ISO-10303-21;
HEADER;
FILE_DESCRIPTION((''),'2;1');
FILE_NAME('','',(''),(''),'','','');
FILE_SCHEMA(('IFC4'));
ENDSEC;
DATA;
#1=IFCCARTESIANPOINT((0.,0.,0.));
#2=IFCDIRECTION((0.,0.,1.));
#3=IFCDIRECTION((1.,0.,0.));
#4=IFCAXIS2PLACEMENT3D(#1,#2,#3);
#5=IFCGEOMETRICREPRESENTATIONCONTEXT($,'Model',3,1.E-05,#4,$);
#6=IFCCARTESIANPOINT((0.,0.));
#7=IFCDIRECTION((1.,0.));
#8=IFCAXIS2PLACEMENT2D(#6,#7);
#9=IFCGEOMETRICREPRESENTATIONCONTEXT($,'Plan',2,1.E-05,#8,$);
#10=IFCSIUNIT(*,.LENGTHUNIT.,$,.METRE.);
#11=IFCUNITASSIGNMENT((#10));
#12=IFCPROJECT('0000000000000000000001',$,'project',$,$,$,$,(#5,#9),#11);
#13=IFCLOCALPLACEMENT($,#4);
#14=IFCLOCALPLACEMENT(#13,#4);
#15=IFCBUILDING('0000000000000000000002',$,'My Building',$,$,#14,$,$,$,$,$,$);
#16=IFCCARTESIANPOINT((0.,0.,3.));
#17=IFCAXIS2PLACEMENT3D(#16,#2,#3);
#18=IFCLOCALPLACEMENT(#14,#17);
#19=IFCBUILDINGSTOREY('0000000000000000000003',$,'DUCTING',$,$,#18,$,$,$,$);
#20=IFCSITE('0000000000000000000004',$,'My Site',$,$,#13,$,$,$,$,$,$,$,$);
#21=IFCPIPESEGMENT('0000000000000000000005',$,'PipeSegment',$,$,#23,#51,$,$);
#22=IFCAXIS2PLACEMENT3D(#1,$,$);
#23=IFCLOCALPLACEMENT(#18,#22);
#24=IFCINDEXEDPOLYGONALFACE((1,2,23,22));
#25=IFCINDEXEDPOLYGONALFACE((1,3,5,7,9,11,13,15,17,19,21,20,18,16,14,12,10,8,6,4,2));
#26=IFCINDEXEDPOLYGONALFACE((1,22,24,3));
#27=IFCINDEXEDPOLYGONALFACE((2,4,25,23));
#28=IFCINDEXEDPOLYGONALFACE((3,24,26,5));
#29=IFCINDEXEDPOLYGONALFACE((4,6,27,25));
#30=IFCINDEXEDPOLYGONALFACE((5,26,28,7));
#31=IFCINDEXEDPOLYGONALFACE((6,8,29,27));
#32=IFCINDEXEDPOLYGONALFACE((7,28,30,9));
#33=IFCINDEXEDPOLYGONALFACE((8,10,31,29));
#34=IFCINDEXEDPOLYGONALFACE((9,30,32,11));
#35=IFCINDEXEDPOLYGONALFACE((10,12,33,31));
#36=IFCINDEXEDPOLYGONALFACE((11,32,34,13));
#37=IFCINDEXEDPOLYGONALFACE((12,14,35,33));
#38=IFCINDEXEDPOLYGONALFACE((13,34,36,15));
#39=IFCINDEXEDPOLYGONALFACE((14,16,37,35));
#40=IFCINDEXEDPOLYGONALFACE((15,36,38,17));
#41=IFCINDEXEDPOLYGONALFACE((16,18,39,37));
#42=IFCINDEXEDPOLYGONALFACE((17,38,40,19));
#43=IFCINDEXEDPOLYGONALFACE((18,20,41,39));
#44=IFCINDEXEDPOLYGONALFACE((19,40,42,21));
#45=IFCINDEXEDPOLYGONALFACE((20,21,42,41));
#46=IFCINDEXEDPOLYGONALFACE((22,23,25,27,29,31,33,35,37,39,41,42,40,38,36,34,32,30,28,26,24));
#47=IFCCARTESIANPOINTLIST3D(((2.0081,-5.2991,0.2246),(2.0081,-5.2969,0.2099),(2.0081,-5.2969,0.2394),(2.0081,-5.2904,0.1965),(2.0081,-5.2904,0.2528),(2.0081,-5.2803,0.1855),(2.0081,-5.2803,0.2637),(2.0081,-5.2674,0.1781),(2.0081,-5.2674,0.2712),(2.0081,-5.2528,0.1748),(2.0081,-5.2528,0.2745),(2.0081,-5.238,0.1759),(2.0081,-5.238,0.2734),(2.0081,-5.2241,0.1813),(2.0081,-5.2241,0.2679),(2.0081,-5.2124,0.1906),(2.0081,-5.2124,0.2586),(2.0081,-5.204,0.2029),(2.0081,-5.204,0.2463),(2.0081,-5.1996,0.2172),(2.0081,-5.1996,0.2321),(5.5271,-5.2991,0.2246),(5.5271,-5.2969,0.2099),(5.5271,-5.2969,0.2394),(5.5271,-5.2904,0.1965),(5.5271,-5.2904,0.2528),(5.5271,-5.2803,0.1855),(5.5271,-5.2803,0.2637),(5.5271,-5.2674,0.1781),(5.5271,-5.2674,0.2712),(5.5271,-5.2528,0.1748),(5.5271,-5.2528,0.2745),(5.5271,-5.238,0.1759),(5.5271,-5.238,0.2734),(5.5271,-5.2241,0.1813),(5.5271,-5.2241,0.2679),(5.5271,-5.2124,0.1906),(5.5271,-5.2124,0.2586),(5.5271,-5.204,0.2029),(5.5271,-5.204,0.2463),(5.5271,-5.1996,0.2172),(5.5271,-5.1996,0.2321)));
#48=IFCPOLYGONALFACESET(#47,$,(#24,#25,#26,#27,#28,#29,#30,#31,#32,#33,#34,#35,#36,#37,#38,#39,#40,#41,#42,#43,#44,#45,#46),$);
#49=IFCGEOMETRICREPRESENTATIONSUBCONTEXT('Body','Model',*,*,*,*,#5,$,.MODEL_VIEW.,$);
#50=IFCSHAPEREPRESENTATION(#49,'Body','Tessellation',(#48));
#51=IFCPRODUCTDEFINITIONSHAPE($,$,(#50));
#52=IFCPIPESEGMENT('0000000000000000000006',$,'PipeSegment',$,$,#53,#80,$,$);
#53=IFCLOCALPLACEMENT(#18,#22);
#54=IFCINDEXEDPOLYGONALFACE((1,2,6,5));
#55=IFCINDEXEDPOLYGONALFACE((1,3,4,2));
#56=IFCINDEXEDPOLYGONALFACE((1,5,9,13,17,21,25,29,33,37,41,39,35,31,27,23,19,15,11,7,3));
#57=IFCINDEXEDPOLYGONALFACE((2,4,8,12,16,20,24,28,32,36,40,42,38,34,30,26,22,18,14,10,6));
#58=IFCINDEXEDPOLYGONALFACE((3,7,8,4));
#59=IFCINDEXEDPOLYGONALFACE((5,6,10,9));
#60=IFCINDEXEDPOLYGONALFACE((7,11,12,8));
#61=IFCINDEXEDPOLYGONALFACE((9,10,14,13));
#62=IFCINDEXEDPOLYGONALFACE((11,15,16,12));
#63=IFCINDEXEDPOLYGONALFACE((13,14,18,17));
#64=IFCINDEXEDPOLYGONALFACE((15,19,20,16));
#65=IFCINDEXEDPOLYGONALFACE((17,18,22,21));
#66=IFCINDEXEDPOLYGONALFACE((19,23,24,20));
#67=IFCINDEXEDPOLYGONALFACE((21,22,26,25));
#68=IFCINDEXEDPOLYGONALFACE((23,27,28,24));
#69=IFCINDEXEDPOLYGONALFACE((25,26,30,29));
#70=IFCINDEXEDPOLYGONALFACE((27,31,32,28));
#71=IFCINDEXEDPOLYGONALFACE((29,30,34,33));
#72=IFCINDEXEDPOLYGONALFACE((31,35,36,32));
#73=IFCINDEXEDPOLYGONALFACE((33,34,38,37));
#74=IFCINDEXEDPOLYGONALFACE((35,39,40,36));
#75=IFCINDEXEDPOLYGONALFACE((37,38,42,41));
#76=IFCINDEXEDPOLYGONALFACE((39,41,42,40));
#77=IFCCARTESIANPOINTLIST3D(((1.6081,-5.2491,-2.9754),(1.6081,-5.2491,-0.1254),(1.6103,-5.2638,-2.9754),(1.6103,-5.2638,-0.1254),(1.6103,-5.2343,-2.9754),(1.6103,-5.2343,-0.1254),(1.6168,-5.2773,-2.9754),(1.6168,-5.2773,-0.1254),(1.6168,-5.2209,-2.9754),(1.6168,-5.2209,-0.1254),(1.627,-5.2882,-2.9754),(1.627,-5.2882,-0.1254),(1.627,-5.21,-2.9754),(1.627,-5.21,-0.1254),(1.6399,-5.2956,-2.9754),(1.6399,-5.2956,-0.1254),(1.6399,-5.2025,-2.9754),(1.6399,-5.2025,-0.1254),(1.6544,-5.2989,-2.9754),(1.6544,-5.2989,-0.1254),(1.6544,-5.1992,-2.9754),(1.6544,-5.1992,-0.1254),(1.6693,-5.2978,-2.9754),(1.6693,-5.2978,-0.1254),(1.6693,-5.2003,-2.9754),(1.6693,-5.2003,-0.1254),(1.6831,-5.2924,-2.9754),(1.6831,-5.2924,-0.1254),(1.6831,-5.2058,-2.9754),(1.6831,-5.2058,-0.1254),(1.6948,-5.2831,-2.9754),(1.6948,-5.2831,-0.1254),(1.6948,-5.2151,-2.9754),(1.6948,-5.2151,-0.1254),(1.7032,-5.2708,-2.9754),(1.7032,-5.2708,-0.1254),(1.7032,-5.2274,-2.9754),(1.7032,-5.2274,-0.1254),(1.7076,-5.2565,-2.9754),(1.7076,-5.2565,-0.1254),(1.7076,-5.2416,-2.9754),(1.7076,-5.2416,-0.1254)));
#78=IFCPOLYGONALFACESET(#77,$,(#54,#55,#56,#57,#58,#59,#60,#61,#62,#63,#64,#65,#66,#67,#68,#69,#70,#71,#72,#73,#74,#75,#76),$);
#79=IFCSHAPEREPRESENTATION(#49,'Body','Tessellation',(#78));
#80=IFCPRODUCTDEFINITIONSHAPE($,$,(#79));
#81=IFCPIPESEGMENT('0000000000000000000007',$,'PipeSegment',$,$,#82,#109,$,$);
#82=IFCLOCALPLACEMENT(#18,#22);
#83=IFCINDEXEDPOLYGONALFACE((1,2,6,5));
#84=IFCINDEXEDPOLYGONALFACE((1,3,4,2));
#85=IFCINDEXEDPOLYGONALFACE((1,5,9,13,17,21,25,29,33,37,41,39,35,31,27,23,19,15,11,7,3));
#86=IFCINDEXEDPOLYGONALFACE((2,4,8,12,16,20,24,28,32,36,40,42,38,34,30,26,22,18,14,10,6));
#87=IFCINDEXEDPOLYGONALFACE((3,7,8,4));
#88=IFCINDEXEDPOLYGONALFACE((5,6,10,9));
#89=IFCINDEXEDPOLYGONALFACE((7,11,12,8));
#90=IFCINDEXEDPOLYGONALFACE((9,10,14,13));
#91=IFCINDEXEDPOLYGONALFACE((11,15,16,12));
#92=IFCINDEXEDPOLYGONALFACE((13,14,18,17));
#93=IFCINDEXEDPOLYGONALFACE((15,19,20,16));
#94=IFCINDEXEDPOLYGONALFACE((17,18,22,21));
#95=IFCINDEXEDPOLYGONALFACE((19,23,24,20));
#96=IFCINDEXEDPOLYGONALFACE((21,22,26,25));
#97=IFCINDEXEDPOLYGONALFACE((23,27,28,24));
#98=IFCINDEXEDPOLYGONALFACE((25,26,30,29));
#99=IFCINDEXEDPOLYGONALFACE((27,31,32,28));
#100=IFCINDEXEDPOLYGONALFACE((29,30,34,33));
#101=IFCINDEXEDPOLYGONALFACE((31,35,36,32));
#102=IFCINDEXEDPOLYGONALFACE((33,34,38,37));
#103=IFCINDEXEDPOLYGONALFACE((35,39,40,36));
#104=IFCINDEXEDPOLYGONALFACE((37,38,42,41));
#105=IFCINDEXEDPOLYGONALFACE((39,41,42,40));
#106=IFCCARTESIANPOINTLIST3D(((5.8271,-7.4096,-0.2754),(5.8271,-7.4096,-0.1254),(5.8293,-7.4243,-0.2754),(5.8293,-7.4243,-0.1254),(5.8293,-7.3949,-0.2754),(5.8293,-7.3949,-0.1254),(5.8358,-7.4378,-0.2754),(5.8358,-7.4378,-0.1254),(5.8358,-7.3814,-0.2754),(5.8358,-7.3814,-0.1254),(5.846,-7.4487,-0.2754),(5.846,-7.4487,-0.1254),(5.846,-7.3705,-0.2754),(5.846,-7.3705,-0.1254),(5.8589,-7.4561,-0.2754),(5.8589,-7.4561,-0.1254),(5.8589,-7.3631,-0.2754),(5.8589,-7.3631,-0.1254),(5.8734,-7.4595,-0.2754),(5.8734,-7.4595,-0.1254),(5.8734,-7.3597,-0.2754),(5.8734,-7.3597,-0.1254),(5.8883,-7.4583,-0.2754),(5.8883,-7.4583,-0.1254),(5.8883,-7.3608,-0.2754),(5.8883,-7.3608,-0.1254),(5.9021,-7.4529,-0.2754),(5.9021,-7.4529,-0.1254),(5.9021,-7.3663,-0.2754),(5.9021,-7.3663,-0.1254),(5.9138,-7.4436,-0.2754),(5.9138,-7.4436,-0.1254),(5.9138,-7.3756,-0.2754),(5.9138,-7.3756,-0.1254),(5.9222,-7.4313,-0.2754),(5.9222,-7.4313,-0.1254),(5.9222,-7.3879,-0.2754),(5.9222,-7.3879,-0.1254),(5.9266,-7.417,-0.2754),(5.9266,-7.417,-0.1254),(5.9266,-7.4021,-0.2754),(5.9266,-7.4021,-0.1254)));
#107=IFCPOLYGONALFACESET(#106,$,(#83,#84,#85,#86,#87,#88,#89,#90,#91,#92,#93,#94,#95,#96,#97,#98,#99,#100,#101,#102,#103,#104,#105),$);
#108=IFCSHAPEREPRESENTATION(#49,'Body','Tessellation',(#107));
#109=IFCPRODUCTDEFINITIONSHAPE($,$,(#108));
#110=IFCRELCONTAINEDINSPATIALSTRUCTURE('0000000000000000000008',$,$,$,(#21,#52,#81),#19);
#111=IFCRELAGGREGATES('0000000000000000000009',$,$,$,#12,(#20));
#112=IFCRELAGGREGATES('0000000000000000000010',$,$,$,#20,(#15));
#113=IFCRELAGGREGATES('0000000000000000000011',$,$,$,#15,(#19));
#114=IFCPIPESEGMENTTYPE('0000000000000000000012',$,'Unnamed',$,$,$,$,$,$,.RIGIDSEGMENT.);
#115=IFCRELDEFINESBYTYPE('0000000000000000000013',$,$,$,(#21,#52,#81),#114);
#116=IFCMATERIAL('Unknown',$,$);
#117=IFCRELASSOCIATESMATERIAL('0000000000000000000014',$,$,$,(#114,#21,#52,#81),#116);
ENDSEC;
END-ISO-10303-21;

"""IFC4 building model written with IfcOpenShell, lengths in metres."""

from ifc_helpers import new_model, si_unit, frame, origin_with_axes, origin_2d_with_axis, place, context, subcontext, project, spatial, circle, extrude, material, material_profile, profile_set, profile_usage, type_object, element, save


model = new_model("IFC4")

# Units and contexts
model_context = context("Model", 3, precision=1e-05, world=origin_with_axes())
plan_context = context("Plan", 2, precision=1e-05, world=origin_2d_with_axis())
body_context = subcontext(model_context, "Body", "Model", "MODEL_VIEW")
ifc_project = project(units=[si_unit("LENGTHUNIT", "METRE")], contexts=[model_context, plan_context])

# Site, building, storey
site_placement = place(None, origin_with_axes())
site = spatial("IfcSite", under=ifc_project, at=site_placement, Name="My Site")
building_placement = place(site_placement, origin_with_axes())
building = spatial("IfcBuilding", under=site, at=building_placement, Name="My Building")
storey_placement = place(building_placement, frame((0.0, 0.0, 3.0), z_axis=(0.0, 0.0, 1.0), x_axis=(1.0, 0.0, 0.0)))
storey = spatial("IfcBuildingStorey", under=building, at=storey_placement, Name="DUCTING")

# Shared definitions
ifc_material = material(Name="Unknown")

# Pipe segments
ifc_material_profile_1 = material_profile(ifc_material, circle(Radius=0.05))
ifc_profile_set_1 = profile_set([ifc_material_profile_1])
pipe_segment_type = type_object("IfcPipeSegmentType", Name="Unnamed", PredefinedType="RIGIDSEGMENT", material=ifc_profile_set_1)
ifc_profile_usage_1 = profile_usage(ifc_profile_set_1, cardinal=5)
pipe_segment_1_placement = place(storey_placement, frame((5.5271, -5.2491, 0.2246), z_axis=(-1.0, 0.0, 0.0), x_axis=(0.0, -1.0, 0.0)))
element("IfcPipeSegment", 1, at=pipe_segment_1_placement, inside=storey, type_object=pipe_segment_type, material=ifc_profile_usage_1, Name="PipeSegment", context=body_context, shape_type="SweptSolid", body=[
    extrude(circle(Radius=0.05), origin_with_axes(), (0.0, 0.0, 1.0), 3.519),
])
ifc_profile_usage_2 = profile_usage(ifc_profile_set_1, cardinal=5)
pipe_segment_2_placement = place(storey_placement, frame((1.6581, -5.2491, -0.1254), z_axis=(0.0, 0.0, -1.0), x_axis=(-1.0, 0.0, 0.0)))
element("IfcPipeSegment", 2, at=pipe_segment_2_placement, inside=storey, type_object=pipe_segment_type, material=ifc_profile_usage_2, Name="PipeSegment", context=body_context, shape_type="SweptSolid", body=[
    extrude(circle(Radius=0.05), origin_with_axes(), (0.0, 0.0, 1.0), 2.85),
])
ifc_profile_usage_3 = profile_usage(ifc_profile_set_1, cardinal=5)
pipe_segment_3_placement = place(storey_placement, frame((5.8771, -7.4096, -0.1254), z_axis=(0.0, 0.0, -1.0), x_axis=(-1.0, 0.0, 0.0)))
element("IfcPipeSegment", 3, at=pipe_segment_3_placement, inside=storey, type_object=pipe_segment_type, material=ifc_profile_usage_3, Name="PipeSegment", context=body_context, shape_type="SweptSolid", body=[
    extrude(circle(Radius=0.05), origin_with_axes(), (0.0, 0.0, 1.0), 0.15),
])

save(model, "model.ifc")
